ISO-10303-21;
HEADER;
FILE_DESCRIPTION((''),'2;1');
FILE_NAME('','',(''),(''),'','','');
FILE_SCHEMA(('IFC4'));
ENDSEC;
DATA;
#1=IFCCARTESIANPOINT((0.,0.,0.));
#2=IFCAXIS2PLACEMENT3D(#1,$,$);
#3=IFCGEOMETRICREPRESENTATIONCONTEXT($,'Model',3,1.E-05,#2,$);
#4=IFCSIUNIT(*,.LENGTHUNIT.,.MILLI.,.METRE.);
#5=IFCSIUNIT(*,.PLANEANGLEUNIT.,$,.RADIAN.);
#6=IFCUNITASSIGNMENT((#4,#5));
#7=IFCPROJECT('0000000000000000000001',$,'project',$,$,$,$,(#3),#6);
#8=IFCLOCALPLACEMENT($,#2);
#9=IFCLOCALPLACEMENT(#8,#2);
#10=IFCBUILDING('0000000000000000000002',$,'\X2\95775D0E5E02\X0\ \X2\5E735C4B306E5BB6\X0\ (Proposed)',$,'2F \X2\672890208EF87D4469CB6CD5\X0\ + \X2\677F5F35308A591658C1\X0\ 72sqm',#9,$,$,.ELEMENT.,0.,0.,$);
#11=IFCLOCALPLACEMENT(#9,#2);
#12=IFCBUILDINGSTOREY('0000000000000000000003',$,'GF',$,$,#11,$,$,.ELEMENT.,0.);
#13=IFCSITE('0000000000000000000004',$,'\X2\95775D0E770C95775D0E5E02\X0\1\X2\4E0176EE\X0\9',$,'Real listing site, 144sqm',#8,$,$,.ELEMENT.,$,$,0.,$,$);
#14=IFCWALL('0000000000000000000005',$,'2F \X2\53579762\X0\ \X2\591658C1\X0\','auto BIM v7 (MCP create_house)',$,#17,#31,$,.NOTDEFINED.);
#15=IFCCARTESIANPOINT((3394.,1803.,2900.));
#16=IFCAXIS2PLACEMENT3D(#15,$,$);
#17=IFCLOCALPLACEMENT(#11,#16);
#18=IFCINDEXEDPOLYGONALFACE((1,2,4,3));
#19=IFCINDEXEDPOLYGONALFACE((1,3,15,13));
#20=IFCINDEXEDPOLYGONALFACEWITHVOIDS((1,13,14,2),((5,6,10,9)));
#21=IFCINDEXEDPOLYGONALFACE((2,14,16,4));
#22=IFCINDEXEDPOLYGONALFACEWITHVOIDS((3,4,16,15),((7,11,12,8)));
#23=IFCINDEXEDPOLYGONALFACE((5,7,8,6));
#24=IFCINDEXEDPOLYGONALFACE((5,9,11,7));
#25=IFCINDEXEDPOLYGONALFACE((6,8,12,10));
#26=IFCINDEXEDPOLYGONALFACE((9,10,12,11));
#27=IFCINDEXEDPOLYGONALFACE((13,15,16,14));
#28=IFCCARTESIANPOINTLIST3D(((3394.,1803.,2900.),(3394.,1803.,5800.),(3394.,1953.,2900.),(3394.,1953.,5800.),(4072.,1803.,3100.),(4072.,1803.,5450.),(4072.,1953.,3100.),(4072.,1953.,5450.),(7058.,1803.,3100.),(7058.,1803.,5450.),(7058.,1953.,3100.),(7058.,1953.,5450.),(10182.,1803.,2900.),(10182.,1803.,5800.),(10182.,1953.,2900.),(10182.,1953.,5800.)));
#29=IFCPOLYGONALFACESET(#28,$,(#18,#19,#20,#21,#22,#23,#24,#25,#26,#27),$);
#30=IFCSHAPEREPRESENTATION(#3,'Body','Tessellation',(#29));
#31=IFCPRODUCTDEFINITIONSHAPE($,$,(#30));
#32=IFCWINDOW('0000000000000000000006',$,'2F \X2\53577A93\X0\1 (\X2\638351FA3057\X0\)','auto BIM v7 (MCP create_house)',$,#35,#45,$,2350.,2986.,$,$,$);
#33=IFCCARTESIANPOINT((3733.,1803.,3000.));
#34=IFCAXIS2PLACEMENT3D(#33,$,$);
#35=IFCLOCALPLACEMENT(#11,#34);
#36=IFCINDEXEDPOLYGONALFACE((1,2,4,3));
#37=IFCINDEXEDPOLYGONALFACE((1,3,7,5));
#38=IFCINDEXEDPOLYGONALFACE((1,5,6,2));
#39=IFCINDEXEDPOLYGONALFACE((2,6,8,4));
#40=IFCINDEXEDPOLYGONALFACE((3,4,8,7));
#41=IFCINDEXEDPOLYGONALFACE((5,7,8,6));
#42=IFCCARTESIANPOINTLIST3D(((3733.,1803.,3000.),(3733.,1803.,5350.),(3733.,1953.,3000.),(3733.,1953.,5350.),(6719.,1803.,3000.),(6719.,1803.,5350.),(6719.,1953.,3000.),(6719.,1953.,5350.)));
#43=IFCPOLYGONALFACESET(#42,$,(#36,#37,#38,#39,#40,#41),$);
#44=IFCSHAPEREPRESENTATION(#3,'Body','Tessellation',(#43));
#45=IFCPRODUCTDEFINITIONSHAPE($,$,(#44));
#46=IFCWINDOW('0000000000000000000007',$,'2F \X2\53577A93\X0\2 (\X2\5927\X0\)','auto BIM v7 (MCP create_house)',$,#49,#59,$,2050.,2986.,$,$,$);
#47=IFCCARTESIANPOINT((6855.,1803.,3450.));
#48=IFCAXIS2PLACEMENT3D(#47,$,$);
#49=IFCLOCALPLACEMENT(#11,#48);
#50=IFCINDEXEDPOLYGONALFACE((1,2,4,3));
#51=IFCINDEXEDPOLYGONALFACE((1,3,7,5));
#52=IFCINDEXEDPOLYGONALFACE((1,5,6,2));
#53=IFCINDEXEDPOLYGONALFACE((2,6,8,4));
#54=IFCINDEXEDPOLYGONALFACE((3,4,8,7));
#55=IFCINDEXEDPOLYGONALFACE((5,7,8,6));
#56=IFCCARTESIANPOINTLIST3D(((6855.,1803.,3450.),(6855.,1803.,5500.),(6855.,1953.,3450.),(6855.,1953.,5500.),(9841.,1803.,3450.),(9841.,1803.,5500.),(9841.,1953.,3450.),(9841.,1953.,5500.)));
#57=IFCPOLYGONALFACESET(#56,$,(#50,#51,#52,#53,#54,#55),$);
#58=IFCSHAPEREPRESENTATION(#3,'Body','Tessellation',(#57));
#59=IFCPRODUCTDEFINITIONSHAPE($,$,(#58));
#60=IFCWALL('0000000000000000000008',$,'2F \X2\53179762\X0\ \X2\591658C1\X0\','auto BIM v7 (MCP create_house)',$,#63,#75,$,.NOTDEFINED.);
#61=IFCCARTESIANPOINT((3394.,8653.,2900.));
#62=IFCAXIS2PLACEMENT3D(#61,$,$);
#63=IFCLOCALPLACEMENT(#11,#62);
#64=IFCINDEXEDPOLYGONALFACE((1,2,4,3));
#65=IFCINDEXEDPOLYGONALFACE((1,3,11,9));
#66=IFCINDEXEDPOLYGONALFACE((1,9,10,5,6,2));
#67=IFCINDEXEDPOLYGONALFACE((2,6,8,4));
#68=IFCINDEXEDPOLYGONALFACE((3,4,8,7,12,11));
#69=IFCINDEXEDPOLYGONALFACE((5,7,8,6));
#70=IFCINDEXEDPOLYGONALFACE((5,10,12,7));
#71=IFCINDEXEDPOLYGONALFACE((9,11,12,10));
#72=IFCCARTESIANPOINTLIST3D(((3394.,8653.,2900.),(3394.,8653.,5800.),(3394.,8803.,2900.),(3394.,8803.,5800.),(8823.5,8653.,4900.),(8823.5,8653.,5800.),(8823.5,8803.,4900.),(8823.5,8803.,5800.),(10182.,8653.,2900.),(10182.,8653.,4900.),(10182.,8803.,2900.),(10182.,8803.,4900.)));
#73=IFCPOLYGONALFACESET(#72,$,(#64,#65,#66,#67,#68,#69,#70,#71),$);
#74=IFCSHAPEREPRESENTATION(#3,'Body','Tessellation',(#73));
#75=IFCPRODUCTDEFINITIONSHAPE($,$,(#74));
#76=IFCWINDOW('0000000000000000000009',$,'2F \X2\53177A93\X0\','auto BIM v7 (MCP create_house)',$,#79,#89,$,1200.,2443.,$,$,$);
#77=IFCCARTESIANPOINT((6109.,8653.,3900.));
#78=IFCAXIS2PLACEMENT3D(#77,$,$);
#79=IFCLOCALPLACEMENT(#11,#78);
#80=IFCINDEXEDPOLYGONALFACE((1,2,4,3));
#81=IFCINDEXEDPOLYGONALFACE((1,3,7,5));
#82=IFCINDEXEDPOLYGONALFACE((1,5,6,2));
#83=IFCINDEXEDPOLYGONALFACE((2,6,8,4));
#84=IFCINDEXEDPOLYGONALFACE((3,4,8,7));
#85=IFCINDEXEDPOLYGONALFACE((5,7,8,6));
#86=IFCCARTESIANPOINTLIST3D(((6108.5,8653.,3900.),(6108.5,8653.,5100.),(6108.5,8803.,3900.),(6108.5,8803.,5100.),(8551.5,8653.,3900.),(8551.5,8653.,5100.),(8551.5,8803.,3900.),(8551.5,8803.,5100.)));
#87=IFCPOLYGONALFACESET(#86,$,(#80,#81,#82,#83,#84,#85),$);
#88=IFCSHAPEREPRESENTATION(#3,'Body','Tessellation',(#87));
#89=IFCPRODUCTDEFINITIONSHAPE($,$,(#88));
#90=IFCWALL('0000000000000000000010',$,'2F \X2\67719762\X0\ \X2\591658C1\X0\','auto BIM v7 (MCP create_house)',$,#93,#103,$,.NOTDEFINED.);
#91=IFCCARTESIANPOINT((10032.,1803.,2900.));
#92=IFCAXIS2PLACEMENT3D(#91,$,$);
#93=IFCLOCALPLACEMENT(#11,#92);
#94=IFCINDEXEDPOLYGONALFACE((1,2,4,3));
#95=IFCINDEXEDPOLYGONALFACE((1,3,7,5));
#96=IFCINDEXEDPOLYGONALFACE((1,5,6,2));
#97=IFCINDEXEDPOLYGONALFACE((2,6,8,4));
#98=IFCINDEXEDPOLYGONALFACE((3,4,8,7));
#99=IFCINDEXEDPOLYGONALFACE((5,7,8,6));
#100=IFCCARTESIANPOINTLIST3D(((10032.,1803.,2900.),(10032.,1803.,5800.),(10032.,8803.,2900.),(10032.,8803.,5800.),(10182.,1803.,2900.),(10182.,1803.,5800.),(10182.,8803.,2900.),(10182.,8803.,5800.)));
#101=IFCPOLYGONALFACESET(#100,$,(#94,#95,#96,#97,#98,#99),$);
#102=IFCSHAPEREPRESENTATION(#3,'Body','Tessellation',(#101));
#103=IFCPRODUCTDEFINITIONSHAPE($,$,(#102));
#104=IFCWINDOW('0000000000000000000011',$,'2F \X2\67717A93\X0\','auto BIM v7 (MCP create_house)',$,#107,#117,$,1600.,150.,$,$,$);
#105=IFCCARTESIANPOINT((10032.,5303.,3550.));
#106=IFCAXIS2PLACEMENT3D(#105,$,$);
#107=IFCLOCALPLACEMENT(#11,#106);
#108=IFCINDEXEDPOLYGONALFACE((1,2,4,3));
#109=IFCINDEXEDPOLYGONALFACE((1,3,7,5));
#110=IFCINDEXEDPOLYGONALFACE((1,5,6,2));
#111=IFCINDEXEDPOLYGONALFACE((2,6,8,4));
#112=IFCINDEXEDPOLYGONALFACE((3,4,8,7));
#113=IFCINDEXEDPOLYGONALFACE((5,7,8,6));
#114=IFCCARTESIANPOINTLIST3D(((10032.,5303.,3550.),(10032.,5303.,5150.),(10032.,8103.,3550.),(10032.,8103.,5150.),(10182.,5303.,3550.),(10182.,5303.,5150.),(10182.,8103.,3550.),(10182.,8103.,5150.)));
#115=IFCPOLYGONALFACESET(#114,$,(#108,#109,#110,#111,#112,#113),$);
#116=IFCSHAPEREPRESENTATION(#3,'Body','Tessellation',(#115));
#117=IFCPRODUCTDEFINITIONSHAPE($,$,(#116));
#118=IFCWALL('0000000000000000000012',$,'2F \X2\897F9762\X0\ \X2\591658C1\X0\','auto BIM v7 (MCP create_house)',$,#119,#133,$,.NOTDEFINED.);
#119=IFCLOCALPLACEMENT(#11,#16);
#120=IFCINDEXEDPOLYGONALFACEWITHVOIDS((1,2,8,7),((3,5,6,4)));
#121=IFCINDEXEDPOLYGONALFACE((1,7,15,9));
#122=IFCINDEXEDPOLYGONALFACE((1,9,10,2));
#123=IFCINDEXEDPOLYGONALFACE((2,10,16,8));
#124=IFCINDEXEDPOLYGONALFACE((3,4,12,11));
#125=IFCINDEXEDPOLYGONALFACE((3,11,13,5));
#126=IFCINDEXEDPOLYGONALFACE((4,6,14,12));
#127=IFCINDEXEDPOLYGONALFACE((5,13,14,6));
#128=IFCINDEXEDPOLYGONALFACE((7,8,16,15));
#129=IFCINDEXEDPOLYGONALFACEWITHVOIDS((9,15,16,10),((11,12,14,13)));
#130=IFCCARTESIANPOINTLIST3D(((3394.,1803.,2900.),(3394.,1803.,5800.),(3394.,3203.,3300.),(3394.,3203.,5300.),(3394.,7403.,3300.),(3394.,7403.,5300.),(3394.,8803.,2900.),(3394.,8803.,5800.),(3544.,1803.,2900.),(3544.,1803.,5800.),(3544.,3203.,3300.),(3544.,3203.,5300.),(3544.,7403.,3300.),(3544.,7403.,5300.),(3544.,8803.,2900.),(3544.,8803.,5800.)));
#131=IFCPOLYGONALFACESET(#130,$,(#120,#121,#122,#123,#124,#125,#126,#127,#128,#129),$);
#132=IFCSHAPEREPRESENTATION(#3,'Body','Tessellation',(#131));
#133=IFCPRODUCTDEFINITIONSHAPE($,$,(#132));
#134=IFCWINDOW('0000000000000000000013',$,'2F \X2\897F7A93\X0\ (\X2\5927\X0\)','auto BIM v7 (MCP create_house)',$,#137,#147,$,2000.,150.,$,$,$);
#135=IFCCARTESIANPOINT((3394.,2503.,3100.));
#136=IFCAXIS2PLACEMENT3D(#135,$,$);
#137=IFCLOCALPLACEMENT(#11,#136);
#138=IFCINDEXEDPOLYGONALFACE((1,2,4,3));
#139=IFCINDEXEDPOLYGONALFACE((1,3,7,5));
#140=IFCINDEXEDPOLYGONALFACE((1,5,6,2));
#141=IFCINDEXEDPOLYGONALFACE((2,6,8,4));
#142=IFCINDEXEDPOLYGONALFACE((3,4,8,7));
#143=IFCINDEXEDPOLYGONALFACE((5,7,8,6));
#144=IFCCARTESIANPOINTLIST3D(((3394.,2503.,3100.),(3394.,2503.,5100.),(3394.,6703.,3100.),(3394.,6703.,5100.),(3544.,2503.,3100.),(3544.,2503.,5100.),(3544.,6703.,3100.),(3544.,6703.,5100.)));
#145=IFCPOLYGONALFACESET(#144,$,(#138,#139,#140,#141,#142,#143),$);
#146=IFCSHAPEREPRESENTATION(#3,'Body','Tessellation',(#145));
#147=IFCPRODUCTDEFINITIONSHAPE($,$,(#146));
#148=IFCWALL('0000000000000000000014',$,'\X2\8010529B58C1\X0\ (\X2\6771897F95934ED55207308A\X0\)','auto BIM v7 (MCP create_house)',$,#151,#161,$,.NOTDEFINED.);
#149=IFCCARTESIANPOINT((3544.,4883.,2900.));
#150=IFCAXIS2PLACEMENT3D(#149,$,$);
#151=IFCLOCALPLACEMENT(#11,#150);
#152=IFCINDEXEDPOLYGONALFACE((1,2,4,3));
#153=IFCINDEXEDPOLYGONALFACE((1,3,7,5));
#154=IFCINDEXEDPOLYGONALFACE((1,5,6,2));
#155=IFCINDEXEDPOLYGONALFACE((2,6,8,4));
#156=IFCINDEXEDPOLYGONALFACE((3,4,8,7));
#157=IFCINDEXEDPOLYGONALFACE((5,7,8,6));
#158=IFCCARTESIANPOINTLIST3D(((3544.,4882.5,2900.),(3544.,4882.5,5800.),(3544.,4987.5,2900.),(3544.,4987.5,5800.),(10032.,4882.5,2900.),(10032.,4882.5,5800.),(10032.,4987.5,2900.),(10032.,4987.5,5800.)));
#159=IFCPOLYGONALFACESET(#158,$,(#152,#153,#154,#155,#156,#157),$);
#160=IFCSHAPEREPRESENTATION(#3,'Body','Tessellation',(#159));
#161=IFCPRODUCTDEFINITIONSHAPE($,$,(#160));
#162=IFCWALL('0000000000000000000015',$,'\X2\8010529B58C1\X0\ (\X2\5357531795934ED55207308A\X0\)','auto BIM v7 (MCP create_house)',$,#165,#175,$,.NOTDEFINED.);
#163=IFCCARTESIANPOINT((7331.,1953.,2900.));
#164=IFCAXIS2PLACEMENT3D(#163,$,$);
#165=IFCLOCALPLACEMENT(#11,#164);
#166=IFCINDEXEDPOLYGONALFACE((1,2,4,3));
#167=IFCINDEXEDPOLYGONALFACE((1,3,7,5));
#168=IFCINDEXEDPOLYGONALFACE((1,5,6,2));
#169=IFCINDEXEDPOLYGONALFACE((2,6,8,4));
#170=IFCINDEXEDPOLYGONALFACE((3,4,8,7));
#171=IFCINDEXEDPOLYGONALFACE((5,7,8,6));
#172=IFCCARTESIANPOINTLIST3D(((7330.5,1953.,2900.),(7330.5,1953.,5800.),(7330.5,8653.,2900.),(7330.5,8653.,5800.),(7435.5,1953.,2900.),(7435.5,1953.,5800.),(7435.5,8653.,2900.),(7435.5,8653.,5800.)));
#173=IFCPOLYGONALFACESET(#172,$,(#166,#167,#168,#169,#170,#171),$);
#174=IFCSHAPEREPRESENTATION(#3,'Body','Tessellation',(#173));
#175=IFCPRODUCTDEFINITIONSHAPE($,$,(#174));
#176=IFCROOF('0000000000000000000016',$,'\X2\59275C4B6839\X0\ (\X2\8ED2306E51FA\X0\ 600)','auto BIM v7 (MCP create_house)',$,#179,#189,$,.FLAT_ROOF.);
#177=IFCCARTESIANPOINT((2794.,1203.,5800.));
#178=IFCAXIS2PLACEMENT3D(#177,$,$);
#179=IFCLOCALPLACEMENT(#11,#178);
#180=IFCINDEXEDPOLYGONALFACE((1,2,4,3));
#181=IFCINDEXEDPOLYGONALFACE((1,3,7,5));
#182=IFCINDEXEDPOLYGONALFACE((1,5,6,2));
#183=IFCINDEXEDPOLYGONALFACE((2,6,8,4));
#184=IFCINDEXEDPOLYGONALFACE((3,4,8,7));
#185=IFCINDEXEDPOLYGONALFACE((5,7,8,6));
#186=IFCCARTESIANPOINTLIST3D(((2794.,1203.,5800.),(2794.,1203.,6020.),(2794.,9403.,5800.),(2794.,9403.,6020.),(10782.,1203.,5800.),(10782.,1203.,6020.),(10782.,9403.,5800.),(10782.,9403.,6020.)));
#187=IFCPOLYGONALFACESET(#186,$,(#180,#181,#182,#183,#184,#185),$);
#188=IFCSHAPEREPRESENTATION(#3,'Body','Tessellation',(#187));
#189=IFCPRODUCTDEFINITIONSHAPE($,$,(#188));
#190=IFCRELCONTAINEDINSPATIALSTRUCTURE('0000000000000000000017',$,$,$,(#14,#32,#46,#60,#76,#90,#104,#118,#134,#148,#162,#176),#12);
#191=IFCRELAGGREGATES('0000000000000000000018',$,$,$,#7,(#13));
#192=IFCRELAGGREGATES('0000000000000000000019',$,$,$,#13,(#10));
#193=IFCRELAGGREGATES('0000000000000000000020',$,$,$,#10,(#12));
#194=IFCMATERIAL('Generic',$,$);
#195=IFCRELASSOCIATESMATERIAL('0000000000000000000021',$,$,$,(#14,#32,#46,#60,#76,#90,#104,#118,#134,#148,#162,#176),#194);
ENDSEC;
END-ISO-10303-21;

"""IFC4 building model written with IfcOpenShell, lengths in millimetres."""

from ifc_helpers import new_model, si_unit, frame, frame_2d, origin, place, context, project, spatial, rectangle, extrude, material, element, fill, save


model = new_model("IFC4")

# Units and contexts
model_context = context("Model", 3, precision=1e-05, world=origin())
ifc_project = project(units=[si_unit("LENGTHUNIT", "METRE", prefix="MILLI"), si_unit("PLANEANGLEUNIT", "RADIAN")], contexts=[model_context])

# Site, building, storey
site_placement = place(None, origin())
site = spatial("IfcSite", under=ifc_project, at=site_placement, Name="長崎県長崎市1丁目9", ObjectType="Real listing site, 144sqm", CompositionType="ELEMENT", RefElevation=0.0)
building_placement = place(site_placement, origin())
building = spatial("IfcBuilding", under=site, at=building_placement, Name="長崎市 平屋の家 (Proposed)", ObjectType="2F 木造軸組構法 + 板張り外壁 72sqm", CompositionType="ELEMENT", ElevationOfRefHeight=0.0, ElevationOfTerrain=0.0)
storey_placement = place(building_placement, origin())
storey = spatial("IfcBuildingStorey", under=building, at=storey_placement, Name="GF", CompositionType="ELEMENT", Elevation=0.0)

# Shared definitions
ifc_material = material(Name="Generic")

# Wall, openings, windows
wall_1_placement = place(storey_placement, frame((3394.0, 1803.0, 2900.0)))
wall_1 = element("IfcWall", 1, at=wall_1_placement, inside=storey, material=ifc_material, Name="2F 南面 外壁", Description="auto BIM v7 (MCP create_house)", PredefinedType="NOTDEFINED", context=model_context, shape_type="SweptSolid", body=[
    extrude(rectangle(XDim=6788.0, YDim=150.0, at=frame_2d((3394.0, 75.0))), frame((3394.0, 1803.0, 2900.0)), (0.0, 0.0, 1.0), 2900.0),
])
opening_1_placement = place(storey_placement, frame((3733.0, 1803.0, 3000.0)))
opening_1 = element("IfcOpeningElement", 2, at=opening_1_placement, cuts=wall_1, PredefinedType="NOTDEFINED", context=model_context, shape_type="SweptSolid", body=[
    extrude(rectangle(XDim=2986.0, YDim=150.0, at=frame_2d((1493.0, 75.0))), frame((3733.0, 1803.0, 3000.0)), (0.0, 0.0, 1.0), 2350.0),
])
opening_2_placement = place(storey_placement, frame((6855.0, 1803.0, 3450.0)))
opening_2 = element("IfcOpeningElement", 3, at=opening_2_placement, cuts=wall_1, PredefinedType="NOTDEFINED", context=model_context, shape_type="SweptSolid", body=[
    extrude(rectangle(XDim=2986.0, YDim=150.0, at=frame_2d((1493.0, 75.0))), frame((6855.0, 1803.0, 3450.0)), (0.0, 0.0, 1.0), 2050.0),
])
window_1_placement = place(storey_placement, frame((3733.0, 1803.0, 3000.0)))
window_1 = element("IfcWindow", 4, at=window_1_placement, inside=storey, material=ifc_material, Name="2F 南窓1 (掃出し)", Description="auto BIM v7 (MCP create_house)", OverallHeight=2350.0, OverallWidth=2986.0, context=model_context, shape_type="SweptSolid", body=[
    extrude(rectangle(XDim=2986.0, YDim=150.0, at=frame_2d((1493.0, 75.0))), frame((3733.0, 1803.0, 3000.0)), (0.0, 0.0, 1.0), 2350.0),
])
fill(opening_1, window_1)
window_2_placement = place(storey_placement, frame((6855.0, 1803.0, 3450.0)))
window_2 = element("IfcWindow", 5, at=window_2_placement, inside=storey, material=ifc_material, Name="2F 南窓2 (大)", Description="auto BIM v7 (MCP create_house)", OverallHeight=2050.0, OverallWidth=2986.0, context=model_context, shape_type="SweptSolid", body=[
    extrude(rectangle(XDim=2986.0, YDim=150.0, at=frame_2d((1493.0, 75.0))), frame((6855.0, 1803.0, 3450.0)), (0.0, 0.0, 1.0), 2050.0),
])
fill(opening_2, window_2)

# Walls, openings, windows
wall_2_placement = place(storey_placement, frame((3394.0, 8653.0, 2900.0)))
wall_2 = element("IfcWall", 6, at=wall_2_placement, inside=storey, material=ifc_material, Name="2F 北面 外壁", Description="auto BIM v7 (MCP create_house)", PredefinedType="NOTDEFINED", context=model_context, shape_type="SweptSolid", body=[
    extrude(rectangle(XDim=6788.0, YDim=150.0, at=frame_2d((3394.0, 75.0))), frame((3394.0, 8653.0, 2900.0)), (0.0, 0.0, 1.0), 2900.0),
])
opening_3_placement = place(storey_placement, frame((6109.0, 8653.0, 3900.0)))
opening_3 = element("IfcOpeningElement", 7, at=opening_3_placement, cuts=wall_2, PredefinedType="NOTDEFINED", context=model_context, shape_type="SweptSolid", body=[
    extrude(rectangle(XDim=2443.0, YDim=150.0, at=frame_2d((1221.0, 75.0))), frame((6109.0, 8653.0, 3900.0)), (0.0, 0.0, 1.0), 1200.0),
])
window_3_placement = place(storey_placement, frame((6109.0, 8653.0, 3900.0)))
window_3 = element("IfcWindow", 8, at=window_3_placement, inside=storey, material=ifc_material, Name="2F 北窓", Description="auto BIM v7 (MCP create_house)", OverallHeight=1200.0, OverallWidth=2443.0, context=model_context, shape_type="SweptSolid", body=[
    extrude(rectangle(XDim=2443.0, YDim=150.0, at=frame_2d((1221.0, 75.0))), frame((6109.0, 8653.0, 3900.0)), (0.0, 0.0, 1.0), 1200.0),
])
fill(opening_3, window_3)
wall_3_placement = place(storey_placement, frame((10032.0, 1803.0, 2900.0)))
wall_3 = element("IfcWall", 9, at=wall_3_placement, inside=storey, material=ifc_material, Name="2F 東面 外壁", Description="auto BIM v7 (MCP create_house)", PredefinedType="NOTDEFINED", context=model_context, shape_type="SweptSolid", body=[
    extrude(rectangle(XDim=150.0, YDim=7000.0, at=frame_2d((75.0, 3500.0))), frame((10032.0, 1803.0, 2900.0)), (0.0, 0.0, 1.0), 2900.0),
])
opening_4_placement = place(storey_placement, frame((10032.0, 5303.0, 3550.0)))
opening_4 = element("IfcOpeningElement", 10, at=opening_4_placement, cuts=wall_3, PredefinedType="NOTDEFINED", context=model_context, shape_type="SweptSolid", body=[
    extrude(rectangle(XDim=150.0, YDim=2800.0, at=frame_2d((75.0, 1400.0))), frame((10032.0, 5303.0, 3550.0)), (0.0, 0.0, 1.0), 1600.0),
])
window_4_placement = place(storey_placement, frame((10032.0, 5303.0, 3550.0)))
window_4 = element("IfcWindow", 11, at=window_4_placement, inside=storey, material=ifc_material, Name="2F 東窓", Description="auto BIM v7 (MCP create_house)", OverallHeight=1600.0, OverallWidth=150.0, context=model_context, shape_type="SweptSolid", body=[
    extrude(rectangle(XDim=150.0, YDim=2800.0, at=frame_2d((75.0, 1400.0))), frame((10032.0, 5303.0, 3550.0)), (0.0, 0.0, 1.0), 1600.0),
])
fill(opening_4, window_4)
wall_4_placement = place(storey_placement, frame((3394.0, 1803.0, 2900.0)))
wall_4 = element("IfcWall", 12, at=wall_4_placement, inside=storey, material=ifc_material, Name="2F 西面 外壁", Description="auto BIM v7 (MCP create_house)", PredefinedType="NOTDEFINED", context=model_context, shape_type="SweptSolid", body=[
    extrude(rectangle(XDim=150.0, YDim=7000.0, at=frame_2d((75.0, 3500.0))), frame((3394.0, 1803.0, 2900.0)), (0.0, 0.0, 1.0), 2900.0),
])
opening_5_placement = place(storey_placement, frame((3394.0, 2503.0, 3100.0)))
opening_5 = element("IfcOpeningElement", 13, at=opening_5_placement, cuts=wall_4, PredefinedType="NOTDEFINED", context=model_context, shape_type="SweptSolid", body=[
    extrude(rectangle(XDim=150.0, YDim=4200.0, at=frame_2d((75.0, 2100.0))), frame((3394.0, 2503.0, 3100.0)), (0.0, 0.0, 1.0), 2000.0),
])
window_5_placement = place(storey_placement, frame((3394.0, 2503.0, 3100.0)))
window_5 = element("IfcWindow", 14, at=window_5_placement, inside=storey, material=ifc_material, Name="2F 西窓 (大)", Description="auto BIM v7 (MCP create_house)", OverallHeight=2000.0, OverallWidth=150.0, context=model_context, shape_type="SweptSolid", body=[
    extrude(rectangle(XDim=150.0, YDim=4200.0, at=frame_2d((75.0, 2100.0))), frame((3394.0, 2503.0, 3100.0)), (0.0, 0.0, 1.0), 2000.0),
])
fill(opening_5, window_5)

# Walls
wall_5_placement = place(storey_placement, frame((3544.0, 4883.0, 2900.0)))
element("IfcWall", 15, at=wall_5_placement, inside=storey, material=ifc_material, Name="耐力壁 (東西間仕切り)", Description="auto BIM v7 (MCP create_house)", PredefinedType="NOTDEFINED", context=model_context, shape_type="SweptSolid", body=[
    extrude(rectangle(XDim=6488.0, YDim=105.0, at=frame_2d((3244.0, 52.0))), frame((3544.0, 4883.0, 2900.0)), (0.0, 0.0, 1.0), 2900.0),
])
wall_6_placement = place(storey_placement, frame((7331.0, 1953.0, 2900.0)))
element("IfcWall", 16, at=wall_6_placement, inside=storey, material=ifc_material, Name="耐力壁 (南北間仕切り)", Description="auto BIM v7 (MCP create_house)", PredefinedType="NOTDEFINED", context=model_context, shape_type="SweptSolid", body=[
    extrude(rectangle(XDim=105.0, YDim=6700.0, at=frame_2d((52.0, 3350.0))), frame((7331.0, 1953.0, 2900.0)), (0.0, 0.0, 1.0), 2900.0),
])

# Roof
roof_placement = place(storey_placement, frame((2794.0, 1203.0, 5800.0)))
element("IfcRoof", 17, at=roof_placement, inside=storey, material=ifc_material, Name="大屋根 (軒の出 600)", Description="auto BIM v7 (MCP create_house)", PredefinedType="FLAT_ROOF", context=model_context, shape_type="SweptSolid", body=[
    extrude(rectangle(XDim=7988.0, YDim=8200.0, at=frame_2d((3994.0, 4100.0))), frame((2794.0, 1203.0, 5800.0)), (0.0, 0.0, 1.0), 220.0),
])

save(model, "model.ifc")
